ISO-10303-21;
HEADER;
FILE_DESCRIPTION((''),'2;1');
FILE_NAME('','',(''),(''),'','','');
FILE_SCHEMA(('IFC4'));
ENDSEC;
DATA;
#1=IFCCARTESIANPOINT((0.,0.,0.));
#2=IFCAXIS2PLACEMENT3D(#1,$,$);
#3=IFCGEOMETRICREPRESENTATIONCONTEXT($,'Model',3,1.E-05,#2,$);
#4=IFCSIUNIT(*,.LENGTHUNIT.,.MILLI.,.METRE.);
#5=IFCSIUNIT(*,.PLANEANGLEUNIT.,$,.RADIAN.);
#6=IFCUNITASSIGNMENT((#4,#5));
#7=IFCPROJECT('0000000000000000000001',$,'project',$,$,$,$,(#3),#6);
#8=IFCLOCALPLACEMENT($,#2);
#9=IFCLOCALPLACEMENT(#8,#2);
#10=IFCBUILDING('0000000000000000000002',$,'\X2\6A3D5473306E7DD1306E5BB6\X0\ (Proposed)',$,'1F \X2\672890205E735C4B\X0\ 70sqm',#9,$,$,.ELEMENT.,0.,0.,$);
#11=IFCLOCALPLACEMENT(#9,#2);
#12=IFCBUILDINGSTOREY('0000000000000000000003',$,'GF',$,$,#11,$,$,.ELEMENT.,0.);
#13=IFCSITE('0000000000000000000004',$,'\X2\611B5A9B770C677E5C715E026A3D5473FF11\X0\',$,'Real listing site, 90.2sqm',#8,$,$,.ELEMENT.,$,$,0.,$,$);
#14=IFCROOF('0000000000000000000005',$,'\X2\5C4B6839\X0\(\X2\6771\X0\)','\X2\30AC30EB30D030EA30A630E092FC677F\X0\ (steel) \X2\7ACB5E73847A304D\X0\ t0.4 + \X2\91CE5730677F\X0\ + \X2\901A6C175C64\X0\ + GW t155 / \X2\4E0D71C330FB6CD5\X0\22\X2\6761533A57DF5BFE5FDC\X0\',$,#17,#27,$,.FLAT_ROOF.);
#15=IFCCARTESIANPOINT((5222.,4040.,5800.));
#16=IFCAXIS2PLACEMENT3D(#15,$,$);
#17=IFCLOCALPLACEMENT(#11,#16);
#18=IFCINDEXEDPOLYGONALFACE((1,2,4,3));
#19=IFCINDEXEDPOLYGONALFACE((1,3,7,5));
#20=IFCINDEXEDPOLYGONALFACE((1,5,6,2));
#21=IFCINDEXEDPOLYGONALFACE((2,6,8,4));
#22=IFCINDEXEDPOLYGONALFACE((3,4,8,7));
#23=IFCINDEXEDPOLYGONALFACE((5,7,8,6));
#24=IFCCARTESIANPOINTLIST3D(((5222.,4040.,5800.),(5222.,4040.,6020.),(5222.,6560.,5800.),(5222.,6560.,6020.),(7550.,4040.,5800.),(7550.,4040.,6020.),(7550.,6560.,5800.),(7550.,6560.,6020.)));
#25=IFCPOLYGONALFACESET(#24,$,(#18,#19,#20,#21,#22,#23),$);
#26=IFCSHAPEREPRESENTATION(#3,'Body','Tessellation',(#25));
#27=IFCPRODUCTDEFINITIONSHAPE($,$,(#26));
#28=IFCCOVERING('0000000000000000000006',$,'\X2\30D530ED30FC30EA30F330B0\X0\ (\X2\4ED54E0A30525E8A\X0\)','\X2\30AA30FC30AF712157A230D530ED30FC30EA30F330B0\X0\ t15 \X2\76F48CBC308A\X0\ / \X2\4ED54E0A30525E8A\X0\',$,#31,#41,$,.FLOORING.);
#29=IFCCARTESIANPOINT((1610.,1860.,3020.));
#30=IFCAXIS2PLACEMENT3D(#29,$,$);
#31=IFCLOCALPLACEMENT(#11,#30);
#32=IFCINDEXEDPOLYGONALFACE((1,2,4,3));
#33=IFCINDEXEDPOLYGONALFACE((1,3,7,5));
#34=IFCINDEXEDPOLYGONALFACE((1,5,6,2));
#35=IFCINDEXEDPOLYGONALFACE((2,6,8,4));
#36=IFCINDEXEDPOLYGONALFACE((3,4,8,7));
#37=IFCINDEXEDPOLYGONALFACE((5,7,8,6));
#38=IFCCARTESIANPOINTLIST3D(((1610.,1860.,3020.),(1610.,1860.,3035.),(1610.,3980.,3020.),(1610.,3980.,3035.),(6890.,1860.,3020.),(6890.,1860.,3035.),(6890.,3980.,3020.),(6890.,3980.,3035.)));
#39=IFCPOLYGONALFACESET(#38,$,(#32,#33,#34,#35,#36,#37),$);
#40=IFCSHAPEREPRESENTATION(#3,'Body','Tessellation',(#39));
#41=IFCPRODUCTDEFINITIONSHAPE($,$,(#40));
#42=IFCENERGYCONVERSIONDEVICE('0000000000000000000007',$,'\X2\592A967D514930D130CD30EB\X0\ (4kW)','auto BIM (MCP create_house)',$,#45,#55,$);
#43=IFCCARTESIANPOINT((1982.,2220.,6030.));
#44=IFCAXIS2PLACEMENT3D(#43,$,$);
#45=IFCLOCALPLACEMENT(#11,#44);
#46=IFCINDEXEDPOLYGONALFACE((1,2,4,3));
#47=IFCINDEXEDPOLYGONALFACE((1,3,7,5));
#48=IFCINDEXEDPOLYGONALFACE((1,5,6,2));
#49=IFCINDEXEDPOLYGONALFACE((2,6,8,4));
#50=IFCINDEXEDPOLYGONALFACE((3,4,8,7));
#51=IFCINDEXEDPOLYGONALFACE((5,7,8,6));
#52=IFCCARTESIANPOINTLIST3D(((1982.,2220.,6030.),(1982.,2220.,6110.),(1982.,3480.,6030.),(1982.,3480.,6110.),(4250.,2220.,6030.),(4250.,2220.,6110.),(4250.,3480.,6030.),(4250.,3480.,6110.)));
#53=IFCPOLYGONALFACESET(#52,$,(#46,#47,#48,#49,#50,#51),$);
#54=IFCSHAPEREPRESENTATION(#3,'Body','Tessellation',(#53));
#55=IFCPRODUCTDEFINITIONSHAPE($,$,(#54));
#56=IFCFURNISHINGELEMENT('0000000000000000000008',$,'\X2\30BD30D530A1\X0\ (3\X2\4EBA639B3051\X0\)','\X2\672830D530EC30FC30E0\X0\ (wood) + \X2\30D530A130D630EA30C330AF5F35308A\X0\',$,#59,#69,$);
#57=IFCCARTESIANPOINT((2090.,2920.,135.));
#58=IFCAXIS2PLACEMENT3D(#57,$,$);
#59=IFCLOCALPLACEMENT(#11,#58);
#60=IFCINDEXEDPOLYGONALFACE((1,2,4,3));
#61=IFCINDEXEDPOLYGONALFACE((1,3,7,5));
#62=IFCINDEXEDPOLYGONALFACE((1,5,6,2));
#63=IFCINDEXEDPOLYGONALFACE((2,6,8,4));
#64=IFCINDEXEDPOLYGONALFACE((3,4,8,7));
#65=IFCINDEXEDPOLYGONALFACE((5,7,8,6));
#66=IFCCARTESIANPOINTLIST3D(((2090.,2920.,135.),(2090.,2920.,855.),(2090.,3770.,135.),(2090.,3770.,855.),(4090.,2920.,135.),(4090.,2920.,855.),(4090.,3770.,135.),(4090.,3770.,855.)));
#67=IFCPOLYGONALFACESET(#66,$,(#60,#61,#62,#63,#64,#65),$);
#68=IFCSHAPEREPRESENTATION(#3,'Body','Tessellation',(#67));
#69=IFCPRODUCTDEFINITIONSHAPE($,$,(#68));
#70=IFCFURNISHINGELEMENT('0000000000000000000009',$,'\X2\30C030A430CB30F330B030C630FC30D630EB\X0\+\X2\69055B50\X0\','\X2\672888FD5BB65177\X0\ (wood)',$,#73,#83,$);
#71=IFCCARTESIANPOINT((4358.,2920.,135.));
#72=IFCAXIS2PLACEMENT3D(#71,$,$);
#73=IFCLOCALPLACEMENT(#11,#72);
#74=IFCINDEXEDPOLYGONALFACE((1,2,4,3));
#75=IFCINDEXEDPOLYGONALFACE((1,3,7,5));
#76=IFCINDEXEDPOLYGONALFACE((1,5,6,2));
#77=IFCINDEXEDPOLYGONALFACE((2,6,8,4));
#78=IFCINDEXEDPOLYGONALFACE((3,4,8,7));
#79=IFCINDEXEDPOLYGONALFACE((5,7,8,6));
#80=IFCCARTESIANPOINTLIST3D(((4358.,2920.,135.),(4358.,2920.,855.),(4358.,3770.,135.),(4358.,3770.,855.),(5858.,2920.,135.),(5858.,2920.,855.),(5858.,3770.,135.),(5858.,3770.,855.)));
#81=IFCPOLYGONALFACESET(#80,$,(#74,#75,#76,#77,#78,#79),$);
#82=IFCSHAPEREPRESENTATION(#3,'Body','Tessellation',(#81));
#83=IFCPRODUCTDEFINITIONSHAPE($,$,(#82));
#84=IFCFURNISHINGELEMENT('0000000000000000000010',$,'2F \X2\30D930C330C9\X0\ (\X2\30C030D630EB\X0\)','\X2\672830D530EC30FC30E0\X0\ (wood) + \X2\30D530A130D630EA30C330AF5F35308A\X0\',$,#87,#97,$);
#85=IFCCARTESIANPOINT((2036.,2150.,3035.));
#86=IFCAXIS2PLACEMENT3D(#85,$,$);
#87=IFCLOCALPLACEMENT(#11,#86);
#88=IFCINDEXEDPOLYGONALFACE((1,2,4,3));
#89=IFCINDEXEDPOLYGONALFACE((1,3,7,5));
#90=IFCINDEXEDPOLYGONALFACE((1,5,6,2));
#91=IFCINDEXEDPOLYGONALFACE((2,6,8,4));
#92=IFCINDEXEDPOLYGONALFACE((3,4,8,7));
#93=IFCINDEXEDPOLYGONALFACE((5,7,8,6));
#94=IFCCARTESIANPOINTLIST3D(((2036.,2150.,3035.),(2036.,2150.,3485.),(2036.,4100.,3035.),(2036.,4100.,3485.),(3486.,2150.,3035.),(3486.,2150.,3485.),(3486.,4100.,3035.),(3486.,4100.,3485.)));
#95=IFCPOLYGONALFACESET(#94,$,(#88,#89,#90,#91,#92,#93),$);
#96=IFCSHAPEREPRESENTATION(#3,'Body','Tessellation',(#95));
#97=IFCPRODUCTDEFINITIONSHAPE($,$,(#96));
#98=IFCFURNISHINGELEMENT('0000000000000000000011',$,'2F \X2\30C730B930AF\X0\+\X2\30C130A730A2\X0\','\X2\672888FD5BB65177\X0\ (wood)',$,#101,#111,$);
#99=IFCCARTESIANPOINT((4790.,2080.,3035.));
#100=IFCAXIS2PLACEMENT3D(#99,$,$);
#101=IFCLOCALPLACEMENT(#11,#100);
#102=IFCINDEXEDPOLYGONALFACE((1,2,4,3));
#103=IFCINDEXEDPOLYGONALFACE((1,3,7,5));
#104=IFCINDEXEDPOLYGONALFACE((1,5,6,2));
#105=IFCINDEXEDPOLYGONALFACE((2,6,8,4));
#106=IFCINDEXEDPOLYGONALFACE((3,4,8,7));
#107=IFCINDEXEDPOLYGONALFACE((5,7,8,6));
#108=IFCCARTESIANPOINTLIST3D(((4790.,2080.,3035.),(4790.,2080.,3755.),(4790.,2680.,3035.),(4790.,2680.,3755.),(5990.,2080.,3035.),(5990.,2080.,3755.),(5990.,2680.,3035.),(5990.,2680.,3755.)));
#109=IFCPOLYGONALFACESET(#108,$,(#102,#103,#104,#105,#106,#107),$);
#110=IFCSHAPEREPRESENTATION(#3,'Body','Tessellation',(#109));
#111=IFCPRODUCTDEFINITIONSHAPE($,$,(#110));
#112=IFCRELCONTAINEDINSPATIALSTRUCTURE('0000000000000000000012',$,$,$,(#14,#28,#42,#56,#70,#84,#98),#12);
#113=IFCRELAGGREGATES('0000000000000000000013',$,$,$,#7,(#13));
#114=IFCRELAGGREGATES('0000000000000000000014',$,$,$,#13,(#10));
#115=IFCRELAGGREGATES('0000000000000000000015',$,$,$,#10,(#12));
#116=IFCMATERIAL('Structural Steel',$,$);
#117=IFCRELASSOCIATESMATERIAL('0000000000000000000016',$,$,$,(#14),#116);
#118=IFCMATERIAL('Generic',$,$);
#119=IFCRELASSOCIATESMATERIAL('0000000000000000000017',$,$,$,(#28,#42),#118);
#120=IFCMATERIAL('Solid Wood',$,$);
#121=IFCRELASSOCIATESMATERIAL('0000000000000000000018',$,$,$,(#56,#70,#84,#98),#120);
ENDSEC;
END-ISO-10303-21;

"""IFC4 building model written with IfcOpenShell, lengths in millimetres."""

from ifc_helpers import new_model, si_unit, frame, frame_2d, origin, place, context, project, spatial, rectangle, extrude, material, element, save


model = new_model("IFC4")

# Units and contexts
model_context = context("Model", 3, precision=1e-05, world=origin())
ifc_project = project(units=[si_unit("LENGTHUNIT", "METRE", prefix="MILLI"), si_unit("PLANEANGLEUNIT", "RADIAN")], contexts=[model_context])

# Site, building, storey
site_placement = place(None, origin())
site = spatial("IfcSite", under=ifc_project, at=site_placement, Name="愛媛県松山市樽味１", ObjectType="Real listing site, 90.2sqm", CompositionType="ELEMENT", RefElevation=0.0)
building_placement = place(site_placement, origin())
building = spatial("IfcBuilding", under=site, at=building_placement, Name="樽味の緑の家 (Proposed)", ObjectType="1F 木造平屋 70sqm", CompositionType="ELEMENT", ElevationOfRefHeight=0.0, ElevationOfTerrain=0.0)
storey_placement = place(building_placement, origin())
storey = spatial("IfcBuildingStorey", under=building, at=storey_placement, Name="GF", CompositionType="ELEMENT", Elevation=0.0)

# Shared definitions
ifc_material_1 = material(Name="Solid Wood")

# Roof
ifc_material_2 = material(Name="Structural Steel")
roof_1_placement = place(storey_placement, frame((5222.0, 4040.0, 5800.0)))
element("IfcRoof", 1, at=roof_1_placement, inside=storey, material=ifc_material_2, Name="屋根(東)", Description="ガルバリウム鋼板 (steel) 立平葺き t0.4 + 野地板 + 通気層 + GW t155 / 不燃・法22条区域対応", PredefinedType="FLAT_ROOF", context=model_context, shape_type="SweptSolid", body=[
    extrude(rectangle(XDim=2328.0, YDim=2520.0, at=frame_2d((1164.0, 1260.0))), frame((5222.0, 4040.0, 5800.0)), (0.0, 0.0, 1.0), 220.0),
])

# Covering
ifc_material_3 = material(Name="Generic")
covering_placement = place(storey_placement, frame((1610.0, 1860.0, 3020.0)))
element("IfcCovering", 2, at=covering_placement, inside=storey, material=ifc_material_3, Name="フローリング (仕上げ床)", Description="オーク無垢フローリング t15 直貼り / 仕上げ床", PredefinedType="FLOORING", context=model_context, shape_type="SweptSolid", body=[
    extrude(rectangle(XDim=5280.0, YDim=2120.0, at=frame_2d((2640.0, 1060.0))), frame((1610.0, 1860.0, 3020.0)), (0.0, 0.0, 1.0), 15.0),
])

# Energy conversion device
energy_conversion_device_placement = place(storey_placement, frame((1982.0, 2220.0, 6030.0)))
element("IfcEnergyConversionDevice", 3, at=energy_conversion_device_placement, inside=storey, material=ifc_material_3, Name="太陽光パネル (4kW)", Description="auto BIM (MCP create_house)", context=model_context, shape_type="SweptSolid", body=[
    extrude(rectangle(XDim=2268.0, YDim=1260.0, at=frame_2d((1134.0, 630.0))), frame((1982.0, 2220.0, 6030.0)), (0.0, 0.0, 1.0), 80.0),
])

# Furnishing elements
furnishing_1_placement = place(storey_placement, frame((2090.0, 2920.0, 135.0)))
element("IfcFurnishingElement", 4, at=furnishing_1_placement, inside=storey, material=ifc_material_1, Name="ソファ (3人掛け)", Description="木フレーム (wood) + ファブリック張り", context=model_context, shape_type="SweptSolid", body=[
    extrude(rectangle(XDim=2000.0, YDim=850.0, at=frame_2d((1000.0, 425.0))), frame((2090.0, 2920.0, 135.0)), (0.0, 0.0, 1.0), 720.0),
])
furnishing_2_placement = place(storey_placement, frame((4358.0, 2920.0, 135.0)))
element("IfcFurnishingElement", 5, at=furnishing_2_placement, inside=storey, material=ifc_material_1, Name="ダイニングテーブル+椅子", Description="木製家具 (wood)", context=model_context, shape_type="SweptSolid", body=[
    extrude(rectangle(XDim=1500.0, YDim=850.0, at=frame_2d((750.0, 425.0))), frame((4358.0, 2920.0, 135.0)), (0.0, 0.0, 1.0), 720.0),
])
furnishing_3_placement = place(storey_placement, frame((2036.0, 2150.0, 3035.0)))
element("IfcFurnishingElement", 6, at=furnishing_3_placement, inside=storey, material=ifc_material_1, Name="2F ベッド (ダブル)", Description="木フレーム (wood) + ファブリック張り", context=model_context, shape_type="SweptSolid", body=[
    extrude(rectangle(XDim=1450.0, YDim=1950.0, at=frame_2d((725.0, 975.0))), frame((2036.0, 2150.0, 3035.0)), (0.0, 0.0, 1.0), 450.0),
])
furnishing_4_placement = place(storey_placement, frame((4790.0, 2080.0, 3035.0)))
element("IfcFurnishingElement", 7, at=furnishing_4_placement, inside=storey, material=ifc_material_1, Name="2F デスク+チェア", Description="木製家具 (wood)", context=model_context, shape_type="SweptSolid", body=[
    extrude(rectangle(XDim=1200.0, YDim=600.0, at=frame_2d((600.0, 300.0))), frame((4790.0, 2080.0, 3035.0)), (0.0, 0.0, 1.0), 720.0),
])

save(model, "model.ifc")
